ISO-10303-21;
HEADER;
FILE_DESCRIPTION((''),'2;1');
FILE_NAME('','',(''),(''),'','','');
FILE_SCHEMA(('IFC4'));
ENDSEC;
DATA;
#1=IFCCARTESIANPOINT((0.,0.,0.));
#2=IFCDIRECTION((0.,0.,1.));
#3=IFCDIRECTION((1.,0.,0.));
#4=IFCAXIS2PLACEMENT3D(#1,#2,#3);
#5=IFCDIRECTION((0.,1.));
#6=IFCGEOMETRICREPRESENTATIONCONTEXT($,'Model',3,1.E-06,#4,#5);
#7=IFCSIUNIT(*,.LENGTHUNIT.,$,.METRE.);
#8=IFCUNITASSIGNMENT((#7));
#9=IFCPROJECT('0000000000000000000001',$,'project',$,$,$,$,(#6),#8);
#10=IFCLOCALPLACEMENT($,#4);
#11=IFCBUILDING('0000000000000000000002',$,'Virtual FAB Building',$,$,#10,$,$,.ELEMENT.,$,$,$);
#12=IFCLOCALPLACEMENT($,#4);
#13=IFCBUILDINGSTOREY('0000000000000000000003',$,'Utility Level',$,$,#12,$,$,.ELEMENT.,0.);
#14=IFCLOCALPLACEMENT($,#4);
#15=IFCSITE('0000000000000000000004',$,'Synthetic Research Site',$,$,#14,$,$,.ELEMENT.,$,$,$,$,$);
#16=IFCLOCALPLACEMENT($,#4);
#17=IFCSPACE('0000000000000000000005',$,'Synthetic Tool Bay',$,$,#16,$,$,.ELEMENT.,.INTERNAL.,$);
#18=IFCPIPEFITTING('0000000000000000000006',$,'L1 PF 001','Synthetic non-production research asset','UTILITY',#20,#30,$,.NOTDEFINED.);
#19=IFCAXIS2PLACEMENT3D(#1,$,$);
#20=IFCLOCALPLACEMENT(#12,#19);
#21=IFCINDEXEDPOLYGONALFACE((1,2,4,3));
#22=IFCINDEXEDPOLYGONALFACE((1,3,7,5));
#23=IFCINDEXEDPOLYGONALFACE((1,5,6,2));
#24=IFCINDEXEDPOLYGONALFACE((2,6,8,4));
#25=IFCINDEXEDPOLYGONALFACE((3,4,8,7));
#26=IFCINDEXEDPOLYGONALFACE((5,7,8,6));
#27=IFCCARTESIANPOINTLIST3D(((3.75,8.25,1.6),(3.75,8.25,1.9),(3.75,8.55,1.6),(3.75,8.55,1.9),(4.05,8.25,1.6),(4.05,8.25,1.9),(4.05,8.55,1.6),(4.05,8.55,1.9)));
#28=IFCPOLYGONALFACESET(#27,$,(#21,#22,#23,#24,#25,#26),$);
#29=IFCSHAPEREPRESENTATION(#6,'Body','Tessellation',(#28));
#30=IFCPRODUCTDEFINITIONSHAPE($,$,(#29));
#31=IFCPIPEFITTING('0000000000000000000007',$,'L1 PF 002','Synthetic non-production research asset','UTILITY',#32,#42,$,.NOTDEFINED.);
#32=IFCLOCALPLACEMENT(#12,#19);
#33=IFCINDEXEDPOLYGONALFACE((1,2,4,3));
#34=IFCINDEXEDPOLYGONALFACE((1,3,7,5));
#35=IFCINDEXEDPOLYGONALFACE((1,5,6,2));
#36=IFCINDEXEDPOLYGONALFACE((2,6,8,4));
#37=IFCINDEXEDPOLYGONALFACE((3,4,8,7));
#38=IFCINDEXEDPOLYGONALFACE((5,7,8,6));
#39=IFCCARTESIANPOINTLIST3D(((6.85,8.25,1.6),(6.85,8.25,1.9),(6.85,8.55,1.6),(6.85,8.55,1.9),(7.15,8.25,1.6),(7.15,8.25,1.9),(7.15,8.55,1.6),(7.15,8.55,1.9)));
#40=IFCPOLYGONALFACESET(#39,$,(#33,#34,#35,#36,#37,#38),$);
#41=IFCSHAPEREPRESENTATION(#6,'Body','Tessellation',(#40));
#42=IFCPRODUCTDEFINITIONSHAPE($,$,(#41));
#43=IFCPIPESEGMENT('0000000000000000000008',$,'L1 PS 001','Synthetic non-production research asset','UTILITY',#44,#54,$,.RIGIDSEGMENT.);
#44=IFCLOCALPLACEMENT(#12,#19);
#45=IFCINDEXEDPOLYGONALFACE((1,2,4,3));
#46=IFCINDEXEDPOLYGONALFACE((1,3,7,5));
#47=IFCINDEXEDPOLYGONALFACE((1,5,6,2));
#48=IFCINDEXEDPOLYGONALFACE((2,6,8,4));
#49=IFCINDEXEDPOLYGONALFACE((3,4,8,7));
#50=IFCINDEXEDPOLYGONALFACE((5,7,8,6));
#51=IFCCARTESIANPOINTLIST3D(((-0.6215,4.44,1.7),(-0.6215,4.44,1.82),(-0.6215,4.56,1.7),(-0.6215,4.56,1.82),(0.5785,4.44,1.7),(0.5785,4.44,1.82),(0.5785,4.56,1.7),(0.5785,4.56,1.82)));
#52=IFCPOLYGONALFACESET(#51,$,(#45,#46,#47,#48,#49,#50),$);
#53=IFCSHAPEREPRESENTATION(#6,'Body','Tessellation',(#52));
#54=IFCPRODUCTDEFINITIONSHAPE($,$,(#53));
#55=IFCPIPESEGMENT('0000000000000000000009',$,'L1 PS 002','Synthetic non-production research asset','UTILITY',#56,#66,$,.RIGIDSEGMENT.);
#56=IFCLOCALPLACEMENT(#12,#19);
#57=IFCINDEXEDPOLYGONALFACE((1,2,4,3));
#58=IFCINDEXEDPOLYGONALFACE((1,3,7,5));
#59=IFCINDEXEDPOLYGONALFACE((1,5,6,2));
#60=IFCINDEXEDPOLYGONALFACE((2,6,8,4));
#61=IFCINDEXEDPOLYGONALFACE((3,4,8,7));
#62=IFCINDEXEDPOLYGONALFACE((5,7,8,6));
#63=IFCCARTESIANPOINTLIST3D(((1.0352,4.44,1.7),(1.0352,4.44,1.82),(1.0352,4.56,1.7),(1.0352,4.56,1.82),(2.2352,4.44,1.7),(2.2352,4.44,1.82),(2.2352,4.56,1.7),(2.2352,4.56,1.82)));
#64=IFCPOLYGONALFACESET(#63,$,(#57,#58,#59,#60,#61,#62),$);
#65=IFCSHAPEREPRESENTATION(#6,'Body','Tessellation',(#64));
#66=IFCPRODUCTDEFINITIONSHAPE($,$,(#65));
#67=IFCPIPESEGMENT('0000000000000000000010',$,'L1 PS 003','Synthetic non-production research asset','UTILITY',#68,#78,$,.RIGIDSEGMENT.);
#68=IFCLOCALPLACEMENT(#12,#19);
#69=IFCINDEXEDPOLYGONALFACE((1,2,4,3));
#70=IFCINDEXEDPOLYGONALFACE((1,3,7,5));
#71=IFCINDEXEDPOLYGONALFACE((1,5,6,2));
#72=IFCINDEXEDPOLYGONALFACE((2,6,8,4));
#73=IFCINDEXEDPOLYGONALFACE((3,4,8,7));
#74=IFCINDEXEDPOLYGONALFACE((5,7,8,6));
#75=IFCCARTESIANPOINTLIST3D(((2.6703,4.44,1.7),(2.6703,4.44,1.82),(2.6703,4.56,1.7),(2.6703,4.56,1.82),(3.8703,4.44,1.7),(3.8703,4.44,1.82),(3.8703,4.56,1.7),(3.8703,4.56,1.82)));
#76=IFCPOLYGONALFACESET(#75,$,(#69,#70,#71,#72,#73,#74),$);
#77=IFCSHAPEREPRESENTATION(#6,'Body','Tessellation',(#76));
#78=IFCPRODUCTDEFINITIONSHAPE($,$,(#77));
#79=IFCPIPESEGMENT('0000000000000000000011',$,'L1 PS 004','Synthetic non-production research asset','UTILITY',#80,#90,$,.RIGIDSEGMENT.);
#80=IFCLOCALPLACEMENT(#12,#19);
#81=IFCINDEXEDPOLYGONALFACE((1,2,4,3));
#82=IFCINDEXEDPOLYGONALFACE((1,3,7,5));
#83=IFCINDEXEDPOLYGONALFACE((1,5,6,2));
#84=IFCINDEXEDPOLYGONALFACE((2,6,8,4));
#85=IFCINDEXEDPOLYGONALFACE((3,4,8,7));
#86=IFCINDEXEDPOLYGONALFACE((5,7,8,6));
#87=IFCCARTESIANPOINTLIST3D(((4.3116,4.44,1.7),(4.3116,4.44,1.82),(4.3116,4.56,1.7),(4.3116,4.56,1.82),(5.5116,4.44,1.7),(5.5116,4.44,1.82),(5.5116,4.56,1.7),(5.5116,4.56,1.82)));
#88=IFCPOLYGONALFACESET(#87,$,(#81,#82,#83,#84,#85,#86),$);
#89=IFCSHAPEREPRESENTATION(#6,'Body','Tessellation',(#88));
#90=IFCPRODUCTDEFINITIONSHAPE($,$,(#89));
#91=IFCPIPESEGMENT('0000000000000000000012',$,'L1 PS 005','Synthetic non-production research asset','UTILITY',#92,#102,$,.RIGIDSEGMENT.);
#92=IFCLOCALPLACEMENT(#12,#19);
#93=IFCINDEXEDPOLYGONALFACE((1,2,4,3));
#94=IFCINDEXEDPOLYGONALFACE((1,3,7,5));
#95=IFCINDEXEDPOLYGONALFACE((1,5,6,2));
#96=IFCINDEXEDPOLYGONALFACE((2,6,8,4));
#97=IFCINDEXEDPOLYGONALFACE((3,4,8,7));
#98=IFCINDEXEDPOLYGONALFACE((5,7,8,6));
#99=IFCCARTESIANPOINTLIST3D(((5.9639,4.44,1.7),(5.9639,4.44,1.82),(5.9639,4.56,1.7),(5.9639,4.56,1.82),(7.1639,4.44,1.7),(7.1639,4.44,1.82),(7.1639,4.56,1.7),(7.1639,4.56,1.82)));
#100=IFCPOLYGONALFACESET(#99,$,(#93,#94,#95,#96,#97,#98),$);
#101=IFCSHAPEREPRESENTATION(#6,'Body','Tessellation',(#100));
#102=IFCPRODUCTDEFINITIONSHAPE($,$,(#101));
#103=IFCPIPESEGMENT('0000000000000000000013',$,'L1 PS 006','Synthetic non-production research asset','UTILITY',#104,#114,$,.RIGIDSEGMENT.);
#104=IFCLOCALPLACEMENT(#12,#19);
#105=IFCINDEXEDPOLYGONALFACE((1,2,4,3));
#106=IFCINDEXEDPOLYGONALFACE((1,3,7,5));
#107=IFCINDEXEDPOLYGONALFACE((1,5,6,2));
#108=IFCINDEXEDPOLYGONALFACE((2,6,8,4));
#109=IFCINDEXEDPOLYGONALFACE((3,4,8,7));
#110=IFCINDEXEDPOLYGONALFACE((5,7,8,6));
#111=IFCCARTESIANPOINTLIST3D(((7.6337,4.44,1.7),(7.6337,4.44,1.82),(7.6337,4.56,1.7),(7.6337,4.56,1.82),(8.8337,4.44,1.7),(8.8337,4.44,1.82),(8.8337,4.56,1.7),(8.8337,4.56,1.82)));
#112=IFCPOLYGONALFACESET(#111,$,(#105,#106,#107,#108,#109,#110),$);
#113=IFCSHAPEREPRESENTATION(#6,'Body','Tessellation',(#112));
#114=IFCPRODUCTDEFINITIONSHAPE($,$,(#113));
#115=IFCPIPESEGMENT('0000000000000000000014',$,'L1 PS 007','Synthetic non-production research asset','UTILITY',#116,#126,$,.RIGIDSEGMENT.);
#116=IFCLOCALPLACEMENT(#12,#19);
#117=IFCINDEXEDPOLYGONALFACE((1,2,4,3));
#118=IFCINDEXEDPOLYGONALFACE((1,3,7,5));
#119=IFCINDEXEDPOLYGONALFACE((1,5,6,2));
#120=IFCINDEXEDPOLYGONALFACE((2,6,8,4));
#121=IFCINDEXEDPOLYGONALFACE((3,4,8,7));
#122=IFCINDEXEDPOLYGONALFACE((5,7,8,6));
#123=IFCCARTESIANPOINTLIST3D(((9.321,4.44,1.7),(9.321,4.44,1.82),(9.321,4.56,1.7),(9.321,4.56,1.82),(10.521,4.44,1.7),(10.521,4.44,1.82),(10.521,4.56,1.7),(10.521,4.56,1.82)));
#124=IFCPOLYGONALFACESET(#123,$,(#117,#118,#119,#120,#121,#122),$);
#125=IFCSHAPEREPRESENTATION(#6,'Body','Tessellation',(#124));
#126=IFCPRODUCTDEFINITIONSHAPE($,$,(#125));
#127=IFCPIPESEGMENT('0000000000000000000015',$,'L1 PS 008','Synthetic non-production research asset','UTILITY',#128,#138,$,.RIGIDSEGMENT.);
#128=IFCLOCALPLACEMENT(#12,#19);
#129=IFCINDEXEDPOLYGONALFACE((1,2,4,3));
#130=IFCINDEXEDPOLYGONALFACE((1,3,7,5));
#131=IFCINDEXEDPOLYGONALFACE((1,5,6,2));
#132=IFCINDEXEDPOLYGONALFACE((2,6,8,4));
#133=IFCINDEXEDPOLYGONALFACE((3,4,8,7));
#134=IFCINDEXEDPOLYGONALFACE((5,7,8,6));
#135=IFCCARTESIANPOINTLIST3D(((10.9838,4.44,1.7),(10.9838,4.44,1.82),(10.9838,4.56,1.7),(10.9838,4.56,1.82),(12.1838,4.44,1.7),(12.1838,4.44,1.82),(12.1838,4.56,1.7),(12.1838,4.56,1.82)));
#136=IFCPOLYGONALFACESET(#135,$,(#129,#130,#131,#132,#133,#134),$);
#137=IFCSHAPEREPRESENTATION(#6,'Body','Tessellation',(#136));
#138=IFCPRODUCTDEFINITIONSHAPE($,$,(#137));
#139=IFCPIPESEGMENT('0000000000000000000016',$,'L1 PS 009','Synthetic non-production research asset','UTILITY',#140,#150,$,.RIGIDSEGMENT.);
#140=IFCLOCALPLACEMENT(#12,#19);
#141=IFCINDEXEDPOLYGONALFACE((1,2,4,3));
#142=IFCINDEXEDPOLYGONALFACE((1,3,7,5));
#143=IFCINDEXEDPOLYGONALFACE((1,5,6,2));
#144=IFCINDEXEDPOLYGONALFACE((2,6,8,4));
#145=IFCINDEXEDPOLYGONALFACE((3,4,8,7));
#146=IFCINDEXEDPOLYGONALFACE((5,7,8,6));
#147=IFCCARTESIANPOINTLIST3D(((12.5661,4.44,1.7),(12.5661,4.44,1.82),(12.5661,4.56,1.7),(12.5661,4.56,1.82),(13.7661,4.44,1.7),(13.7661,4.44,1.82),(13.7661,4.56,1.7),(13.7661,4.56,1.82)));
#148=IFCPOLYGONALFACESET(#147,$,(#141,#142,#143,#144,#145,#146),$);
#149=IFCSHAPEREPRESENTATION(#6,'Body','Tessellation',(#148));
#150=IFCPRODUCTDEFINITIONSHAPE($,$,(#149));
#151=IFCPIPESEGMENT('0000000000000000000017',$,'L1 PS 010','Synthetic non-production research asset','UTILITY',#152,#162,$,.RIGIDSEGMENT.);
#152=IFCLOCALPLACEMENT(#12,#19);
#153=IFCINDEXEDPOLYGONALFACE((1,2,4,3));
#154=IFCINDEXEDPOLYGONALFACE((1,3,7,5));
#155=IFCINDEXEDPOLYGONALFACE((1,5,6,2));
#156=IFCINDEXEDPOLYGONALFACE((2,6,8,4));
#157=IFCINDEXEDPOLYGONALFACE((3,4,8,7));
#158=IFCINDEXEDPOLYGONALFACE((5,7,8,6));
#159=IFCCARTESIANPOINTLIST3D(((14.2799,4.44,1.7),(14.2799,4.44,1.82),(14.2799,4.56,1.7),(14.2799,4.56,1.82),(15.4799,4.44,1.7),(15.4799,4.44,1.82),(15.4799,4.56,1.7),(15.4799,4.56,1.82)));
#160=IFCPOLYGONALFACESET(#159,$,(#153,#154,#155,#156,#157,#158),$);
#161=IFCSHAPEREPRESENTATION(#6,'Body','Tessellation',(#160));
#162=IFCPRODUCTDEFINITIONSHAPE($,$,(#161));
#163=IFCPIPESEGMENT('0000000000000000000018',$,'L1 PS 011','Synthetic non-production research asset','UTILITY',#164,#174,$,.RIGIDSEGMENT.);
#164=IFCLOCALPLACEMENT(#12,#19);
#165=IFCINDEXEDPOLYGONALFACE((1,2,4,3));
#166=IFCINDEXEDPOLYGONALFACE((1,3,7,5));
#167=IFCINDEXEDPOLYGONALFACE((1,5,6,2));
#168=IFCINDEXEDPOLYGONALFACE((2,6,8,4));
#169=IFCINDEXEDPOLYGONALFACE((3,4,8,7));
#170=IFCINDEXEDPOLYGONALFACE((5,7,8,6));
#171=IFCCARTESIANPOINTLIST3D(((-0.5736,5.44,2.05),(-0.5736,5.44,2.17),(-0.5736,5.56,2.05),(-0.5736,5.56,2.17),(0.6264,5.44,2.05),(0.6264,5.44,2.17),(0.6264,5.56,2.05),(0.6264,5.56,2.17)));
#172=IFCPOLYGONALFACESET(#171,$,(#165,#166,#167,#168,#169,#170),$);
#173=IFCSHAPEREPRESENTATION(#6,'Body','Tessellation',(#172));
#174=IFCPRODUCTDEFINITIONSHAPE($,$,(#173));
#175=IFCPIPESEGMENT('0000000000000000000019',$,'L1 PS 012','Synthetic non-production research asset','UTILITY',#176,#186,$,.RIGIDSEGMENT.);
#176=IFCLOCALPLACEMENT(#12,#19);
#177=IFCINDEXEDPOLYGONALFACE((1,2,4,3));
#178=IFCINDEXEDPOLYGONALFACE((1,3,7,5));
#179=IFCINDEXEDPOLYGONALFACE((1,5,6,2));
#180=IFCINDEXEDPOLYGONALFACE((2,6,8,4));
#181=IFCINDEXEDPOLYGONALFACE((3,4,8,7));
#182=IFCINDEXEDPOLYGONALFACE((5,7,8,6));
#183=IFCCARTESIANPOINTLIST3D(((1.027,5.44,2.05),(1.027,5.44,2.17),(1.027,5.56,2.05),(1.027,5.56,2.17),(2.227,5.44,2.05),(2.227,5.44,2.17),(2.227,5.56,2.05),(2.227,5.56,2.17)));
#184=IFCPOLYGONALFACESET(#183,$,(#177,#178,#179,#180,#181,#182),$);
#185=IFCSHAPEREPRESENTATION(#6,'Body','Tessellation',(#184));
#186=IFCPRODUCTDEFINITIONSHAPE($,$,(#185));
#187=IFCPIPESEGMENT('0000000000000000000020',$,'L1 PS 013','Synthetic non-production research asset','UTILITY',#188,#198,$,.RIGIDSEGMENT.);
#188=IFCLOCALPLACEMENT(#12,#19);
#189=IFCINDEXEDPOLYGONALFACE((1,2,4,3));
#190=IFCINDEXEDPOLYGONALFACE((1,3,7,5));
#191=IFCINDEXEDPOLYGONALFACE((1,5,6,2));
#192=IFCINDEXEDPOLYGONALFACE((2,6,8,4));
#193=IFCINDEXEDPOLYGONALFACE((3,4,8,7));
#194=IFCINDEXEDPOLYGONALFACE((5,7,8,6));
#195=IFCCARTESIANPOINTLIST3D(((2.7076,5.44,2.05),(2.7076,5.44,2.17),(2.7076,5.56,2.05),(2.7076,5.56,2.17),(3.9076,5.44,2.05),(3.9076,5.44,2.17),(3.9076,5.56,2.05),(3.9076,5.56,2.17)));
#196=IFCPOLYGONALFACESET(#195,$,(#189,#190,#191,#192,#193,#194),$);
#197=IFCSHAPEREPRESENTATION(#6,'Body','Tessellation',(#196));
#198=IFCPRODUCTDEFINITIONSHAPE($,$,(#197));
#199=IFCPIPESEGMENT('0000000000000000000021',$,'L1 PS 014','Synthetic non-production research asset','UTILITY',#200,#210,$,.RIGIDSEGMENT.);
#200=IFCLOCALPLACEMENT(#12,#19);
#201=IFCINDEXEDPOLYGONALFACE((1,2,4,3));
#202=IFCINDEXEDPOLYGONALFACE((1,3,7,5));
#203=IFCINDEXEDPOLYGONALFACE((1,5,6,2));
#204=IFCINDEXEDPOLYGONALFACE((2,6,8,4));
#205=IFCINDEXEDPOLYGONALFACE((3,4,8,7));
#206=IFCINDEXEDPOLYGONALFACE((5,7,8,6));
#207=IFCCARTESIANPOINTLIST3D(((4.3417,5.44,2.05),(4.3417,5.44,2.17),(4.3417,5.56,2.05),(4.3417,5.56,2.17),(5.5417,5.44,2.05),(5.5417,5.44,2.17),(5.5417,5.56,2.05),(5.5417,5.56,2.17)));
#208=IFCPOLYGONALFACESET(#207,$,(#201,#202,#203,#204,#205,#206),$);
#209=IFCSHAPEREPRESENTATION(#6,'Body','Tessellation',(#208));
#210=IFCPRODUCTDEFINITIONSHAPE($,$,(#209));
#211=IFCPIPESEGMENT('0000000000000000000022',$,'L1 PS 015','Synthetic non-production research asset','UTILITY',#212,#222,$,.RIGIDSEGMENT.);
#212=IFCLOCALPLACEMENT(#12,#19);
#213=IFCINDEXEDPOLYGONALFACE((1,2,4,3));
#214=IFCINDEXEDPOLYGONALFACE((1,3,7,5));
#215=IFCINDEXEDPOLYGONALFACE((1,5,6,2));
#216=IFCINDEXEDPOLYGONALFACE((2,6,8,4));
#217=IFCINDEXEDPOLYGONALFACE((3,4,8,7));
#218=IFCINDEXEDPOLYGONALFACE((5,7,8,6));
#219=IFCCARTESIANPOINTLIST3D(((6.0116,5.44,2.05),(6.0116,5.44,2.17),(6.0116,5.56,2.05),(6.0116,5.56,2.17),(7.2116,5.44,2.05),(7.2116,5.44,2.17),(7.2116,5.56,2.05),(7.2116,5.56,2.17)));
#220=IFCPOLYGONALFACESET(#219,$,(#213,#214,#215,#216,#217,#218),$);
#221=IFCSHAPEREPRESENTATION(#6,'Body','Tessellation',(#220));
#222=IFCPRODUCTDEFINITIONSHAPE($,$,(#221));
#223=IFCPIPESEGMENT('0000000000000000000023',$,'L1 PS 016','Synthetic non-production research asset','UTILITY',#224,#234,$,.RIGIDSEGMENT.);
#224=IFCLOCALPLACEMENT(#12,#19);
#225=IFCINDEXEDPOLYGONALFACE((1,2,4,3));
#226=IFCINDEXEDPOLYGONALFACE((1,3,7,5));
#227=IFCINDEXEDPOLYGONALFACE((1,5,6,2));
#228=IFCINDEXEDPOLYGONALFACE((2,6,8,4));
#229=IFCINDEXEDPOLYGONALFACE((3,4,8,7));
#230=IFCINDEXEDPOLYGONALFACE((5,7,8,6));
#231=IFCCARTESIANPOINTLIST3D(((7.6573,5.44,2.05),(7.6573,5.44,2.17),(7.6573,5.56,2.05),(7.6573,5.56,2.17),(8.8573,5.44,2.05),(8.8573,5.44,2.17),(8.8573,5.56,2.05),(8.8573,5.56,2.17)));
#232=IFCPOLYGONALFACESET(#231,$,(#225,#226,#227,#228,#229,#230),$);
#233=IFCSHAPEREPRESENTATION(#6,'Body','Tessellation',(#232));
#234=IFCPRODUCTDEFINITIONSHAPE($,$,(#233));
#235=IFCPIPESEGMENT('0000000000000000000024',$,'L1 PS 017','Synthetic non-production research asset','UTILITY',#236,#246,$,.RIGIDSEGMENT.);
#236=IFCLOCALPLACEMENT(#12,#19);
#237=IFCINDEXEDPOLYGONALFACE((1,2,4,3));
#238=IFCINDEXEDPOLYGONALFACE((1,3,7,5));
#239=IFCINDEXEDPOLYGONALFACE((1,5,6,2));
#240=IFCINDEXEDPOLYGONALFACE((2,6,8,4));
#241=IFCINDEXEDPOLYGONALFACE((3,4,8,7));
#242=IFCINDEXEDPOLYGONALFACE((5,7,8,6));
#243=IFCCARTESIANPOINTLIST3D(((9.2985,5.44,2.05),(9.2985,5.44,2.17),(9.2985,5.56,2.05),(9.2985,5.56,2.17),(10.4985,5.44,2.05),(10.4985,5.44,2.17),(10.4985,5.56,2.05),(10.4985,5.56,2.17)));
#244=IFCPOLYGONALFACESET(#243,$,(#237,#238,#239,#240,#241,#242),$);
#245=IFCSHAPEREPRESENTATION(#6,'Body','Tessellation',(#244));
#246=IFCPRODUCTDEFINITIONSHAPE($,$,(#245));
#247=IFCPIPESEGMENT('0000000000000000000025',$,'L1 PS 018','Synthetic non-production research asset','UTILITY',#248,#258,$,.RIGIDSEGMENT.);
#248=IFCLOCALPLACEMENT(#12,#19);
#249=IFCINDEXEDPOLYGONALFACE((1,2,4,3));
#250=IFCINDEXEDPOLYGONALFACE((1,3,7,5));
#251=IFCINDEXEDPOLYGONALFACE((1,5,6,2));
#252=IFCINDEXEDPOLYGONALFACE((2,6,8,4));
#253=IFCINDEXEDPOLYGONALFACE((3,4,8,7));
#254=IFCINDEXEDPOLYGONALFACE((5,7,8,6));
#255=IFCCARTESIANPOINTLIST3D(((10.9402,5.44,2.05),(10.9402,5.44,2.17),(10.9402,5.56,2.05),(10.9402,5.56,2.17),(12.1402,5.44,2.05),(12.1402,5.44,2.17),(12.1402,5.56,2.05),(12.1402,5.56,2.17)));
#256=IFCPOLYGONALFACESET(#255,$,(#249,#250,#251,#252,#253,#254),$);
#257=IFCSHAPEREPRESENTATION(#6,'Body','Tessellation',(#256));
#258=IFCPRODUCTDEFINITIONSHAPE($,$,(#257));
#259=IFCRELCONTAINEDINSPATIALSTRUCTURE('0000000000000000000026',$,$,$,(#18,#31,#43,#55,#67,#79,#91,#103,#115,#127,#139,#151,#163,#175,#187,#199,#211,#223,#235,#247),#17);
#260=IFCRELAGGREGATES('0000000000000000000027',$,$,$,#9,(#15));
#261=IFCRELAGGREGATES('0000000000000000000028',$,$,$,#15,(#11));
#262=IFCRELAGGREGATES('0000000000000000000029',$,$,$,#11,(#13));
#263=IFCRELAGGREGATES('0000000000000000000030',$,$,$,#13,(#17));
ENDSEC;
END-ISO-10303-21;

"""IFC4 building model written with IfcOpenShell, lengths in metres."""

from ifc_helpers import new_model, si_unit, direction, frame, origin_with_axes, origin_2d_with_axis, place, context, project, spatial, rectangle, extrude, element, save


model = new_model("IFC4")

# Units and contexts
model_context = context("Model", 3, precision=1e-06, world=origin_with_axes(), true_north=direction((0.0, 1.0)))
ifc_project = project(units=[si_unit("LENGTHUNIT", "METRE")], contexts=[model_context])

# Site, building, storey, space
site_placement = place(None, origin_with_axes())
site = spatial("IfcSite", under=ifc_project, at=site_placement, Name="Synthetic Research Site", CompositionType="ELEMENT")
building_placement = place(None, origin_with_axes())
building = spatial("IfcBuilding", under=site, at=building_placement, Name="Virtual FAB Building", CompositionType="ELEMENT")
storey_placement = place(None, origin_with_axes())
storey = spatial("IfcBuildingStorey", under=building, at=storey_placement, Name="Utility Level", CompositionType="ELEMENT", Elevation=0.0)
space_placement = place(None, origin_with_axes())
space = spatial("IfcSpace", under=storey, at=space_placement, Name="Synthetic Tool Bay", CompositionType="ELEMENT", PredefinedType="INTERNAL")

# Pipe fittings
for number, where, z_axis, x_axis, name in (
    (1, (3.9, 8.4, 1.6), (0.0, 0.0, 1.0), (1.0, 0.0, 0.0), "L1 PF 001"),
    (2, (7.0, 8.4, 1.6), (0.0, 0.0, 1.0), (1.0, 0.0, 0.0), "L1 PF 002"),
):
    element("IfcPipeFitting", number, at=place(None, frame(where, z_axis=z_axis, x_axis=x_axis)), inside=space, Name=name, Description="Synthetic non-production research asset", ObjectType="UTILITY", PredefinedType="NOTDEFINED", context=model_context, shape_type="SweptSolid", body=[
        extrude(rectangle(XDim=0.3, YDim=0.3, at=origin_2d_with_axis()), origin_with_axes(), (0.0, 0.0, 1.0), 0.3),
    ])

# Pipe segments
for number, where, z_axis, x_axis, name in (
    (3, (-0.0215, 4.5, 1.7), (0.0, 0.0, 1.0), (1.0, 0.0, 0.0), "L1 PS 001"),
    (4, (1.6352, 4.5, 1.7), (0.0, 0.0, 1.0), (1.0, 0.0, 0.0), "L1 PS 002"),
    (5, (3.2703, 4.5, 1.7), (0.0, 0.0, 1.0), (1.0, 0.0, 0.0), "L1 PS 003"),
    (6, (4.9116, 4.5, 1.7), (0.0, 0.0, 1.0), (1.0, 0.0, 0.0), "L1 PS 004"),
    (7, (6.5639, 4.5, 1.7), (0.0, 0.0, 1.0), (1.0, 0.0, 0.0), "L1 PS 005"),
    (8, (8.2337, 4.5, 1.7), (0.0, 0.0, 1.0), (1.0, 0.0, 0.0), "L1 PS 006"),
    (9, (9.921, 4.5, 1.7), (0.0, 0.0, 1.0), (1.0, 0.0, 0.0), "L1 PS 007"),
    (10, (11.5838, 4.5, 1.7), (0.0, 0.0, 1.0), (1.0, 0.0, 0.0), "L1 PS 008"),
    (11, (13.1661, 4.5, 1.7), (0.0, 0.0, 1.0), (1.0, 0.0, 0.0), "L1 PS 009"),
    (12, (14.8799, 4.5, 1.7), (0.0, 0.0, 1.0), (1.0, 0.0, 0.0), "L1 PS 010"),
    (13, (0.0264, 5.5, 2.05), (0.0, 0.0, 1.0), (1.0, 0.0, 0.0), "L1 PS 011"),
    (14, (1.627, 5.5, 2.05), (0.0, 0.0, 1.0), (1.0, 0.0, 0.0), "L1 PS 012"),
    (15, (3.3076, 5.5, 2.05), (0.0, 0.0, 1.0), (1.0, 0.0, 0.0), "L1 PS 013"),
    (16, (4.9417, 5.5, 2.05), (0.0, 0.0, 1.0), (1.0, 0.0, 0.0), "L1 PS 014"),
    (17, (6.6116, 5.5, 2.05), (0.0, 0.0, 1.0), (1.0, 0.0, 0.0), "L1 PS 015"),
    (18, (8.2573, 5.5, 2.05), (0.0, 0.0, 1.0), (1.0, 0.0, 0.0), "L1 PS 016"),
    (19, (9.8985, 5.5, 2.05), (0.0, 0.0, 1.0), (1.0, 0.0, 0.0), "L1 PS 017"),
    (20, (11.5402, 5.5, 2.05), (0.0, 0.0, 1.0), (1.0, 0.0, 0.0), "L1 PS 018"),
):
    element("IfcPipeSegment", number, at=place(None, frame(where, z_axis=z_axis, x_axis=x_axis)), inside=space, Name=name, Description="Synthetic non-production research asset", ObjectType="UTILITY", PredefinedType="RIGIDSEGMENT", context=model_context, shape_type="SweptSolid", body=[
        extrude(rectangle(XDim=1.2, YDim=0.12, at=origin_2d_with_axis()), origin_with_axes(), (0.0, 0.0, 1.0), 0.12),
    ])

save(model, "model.ifc")
